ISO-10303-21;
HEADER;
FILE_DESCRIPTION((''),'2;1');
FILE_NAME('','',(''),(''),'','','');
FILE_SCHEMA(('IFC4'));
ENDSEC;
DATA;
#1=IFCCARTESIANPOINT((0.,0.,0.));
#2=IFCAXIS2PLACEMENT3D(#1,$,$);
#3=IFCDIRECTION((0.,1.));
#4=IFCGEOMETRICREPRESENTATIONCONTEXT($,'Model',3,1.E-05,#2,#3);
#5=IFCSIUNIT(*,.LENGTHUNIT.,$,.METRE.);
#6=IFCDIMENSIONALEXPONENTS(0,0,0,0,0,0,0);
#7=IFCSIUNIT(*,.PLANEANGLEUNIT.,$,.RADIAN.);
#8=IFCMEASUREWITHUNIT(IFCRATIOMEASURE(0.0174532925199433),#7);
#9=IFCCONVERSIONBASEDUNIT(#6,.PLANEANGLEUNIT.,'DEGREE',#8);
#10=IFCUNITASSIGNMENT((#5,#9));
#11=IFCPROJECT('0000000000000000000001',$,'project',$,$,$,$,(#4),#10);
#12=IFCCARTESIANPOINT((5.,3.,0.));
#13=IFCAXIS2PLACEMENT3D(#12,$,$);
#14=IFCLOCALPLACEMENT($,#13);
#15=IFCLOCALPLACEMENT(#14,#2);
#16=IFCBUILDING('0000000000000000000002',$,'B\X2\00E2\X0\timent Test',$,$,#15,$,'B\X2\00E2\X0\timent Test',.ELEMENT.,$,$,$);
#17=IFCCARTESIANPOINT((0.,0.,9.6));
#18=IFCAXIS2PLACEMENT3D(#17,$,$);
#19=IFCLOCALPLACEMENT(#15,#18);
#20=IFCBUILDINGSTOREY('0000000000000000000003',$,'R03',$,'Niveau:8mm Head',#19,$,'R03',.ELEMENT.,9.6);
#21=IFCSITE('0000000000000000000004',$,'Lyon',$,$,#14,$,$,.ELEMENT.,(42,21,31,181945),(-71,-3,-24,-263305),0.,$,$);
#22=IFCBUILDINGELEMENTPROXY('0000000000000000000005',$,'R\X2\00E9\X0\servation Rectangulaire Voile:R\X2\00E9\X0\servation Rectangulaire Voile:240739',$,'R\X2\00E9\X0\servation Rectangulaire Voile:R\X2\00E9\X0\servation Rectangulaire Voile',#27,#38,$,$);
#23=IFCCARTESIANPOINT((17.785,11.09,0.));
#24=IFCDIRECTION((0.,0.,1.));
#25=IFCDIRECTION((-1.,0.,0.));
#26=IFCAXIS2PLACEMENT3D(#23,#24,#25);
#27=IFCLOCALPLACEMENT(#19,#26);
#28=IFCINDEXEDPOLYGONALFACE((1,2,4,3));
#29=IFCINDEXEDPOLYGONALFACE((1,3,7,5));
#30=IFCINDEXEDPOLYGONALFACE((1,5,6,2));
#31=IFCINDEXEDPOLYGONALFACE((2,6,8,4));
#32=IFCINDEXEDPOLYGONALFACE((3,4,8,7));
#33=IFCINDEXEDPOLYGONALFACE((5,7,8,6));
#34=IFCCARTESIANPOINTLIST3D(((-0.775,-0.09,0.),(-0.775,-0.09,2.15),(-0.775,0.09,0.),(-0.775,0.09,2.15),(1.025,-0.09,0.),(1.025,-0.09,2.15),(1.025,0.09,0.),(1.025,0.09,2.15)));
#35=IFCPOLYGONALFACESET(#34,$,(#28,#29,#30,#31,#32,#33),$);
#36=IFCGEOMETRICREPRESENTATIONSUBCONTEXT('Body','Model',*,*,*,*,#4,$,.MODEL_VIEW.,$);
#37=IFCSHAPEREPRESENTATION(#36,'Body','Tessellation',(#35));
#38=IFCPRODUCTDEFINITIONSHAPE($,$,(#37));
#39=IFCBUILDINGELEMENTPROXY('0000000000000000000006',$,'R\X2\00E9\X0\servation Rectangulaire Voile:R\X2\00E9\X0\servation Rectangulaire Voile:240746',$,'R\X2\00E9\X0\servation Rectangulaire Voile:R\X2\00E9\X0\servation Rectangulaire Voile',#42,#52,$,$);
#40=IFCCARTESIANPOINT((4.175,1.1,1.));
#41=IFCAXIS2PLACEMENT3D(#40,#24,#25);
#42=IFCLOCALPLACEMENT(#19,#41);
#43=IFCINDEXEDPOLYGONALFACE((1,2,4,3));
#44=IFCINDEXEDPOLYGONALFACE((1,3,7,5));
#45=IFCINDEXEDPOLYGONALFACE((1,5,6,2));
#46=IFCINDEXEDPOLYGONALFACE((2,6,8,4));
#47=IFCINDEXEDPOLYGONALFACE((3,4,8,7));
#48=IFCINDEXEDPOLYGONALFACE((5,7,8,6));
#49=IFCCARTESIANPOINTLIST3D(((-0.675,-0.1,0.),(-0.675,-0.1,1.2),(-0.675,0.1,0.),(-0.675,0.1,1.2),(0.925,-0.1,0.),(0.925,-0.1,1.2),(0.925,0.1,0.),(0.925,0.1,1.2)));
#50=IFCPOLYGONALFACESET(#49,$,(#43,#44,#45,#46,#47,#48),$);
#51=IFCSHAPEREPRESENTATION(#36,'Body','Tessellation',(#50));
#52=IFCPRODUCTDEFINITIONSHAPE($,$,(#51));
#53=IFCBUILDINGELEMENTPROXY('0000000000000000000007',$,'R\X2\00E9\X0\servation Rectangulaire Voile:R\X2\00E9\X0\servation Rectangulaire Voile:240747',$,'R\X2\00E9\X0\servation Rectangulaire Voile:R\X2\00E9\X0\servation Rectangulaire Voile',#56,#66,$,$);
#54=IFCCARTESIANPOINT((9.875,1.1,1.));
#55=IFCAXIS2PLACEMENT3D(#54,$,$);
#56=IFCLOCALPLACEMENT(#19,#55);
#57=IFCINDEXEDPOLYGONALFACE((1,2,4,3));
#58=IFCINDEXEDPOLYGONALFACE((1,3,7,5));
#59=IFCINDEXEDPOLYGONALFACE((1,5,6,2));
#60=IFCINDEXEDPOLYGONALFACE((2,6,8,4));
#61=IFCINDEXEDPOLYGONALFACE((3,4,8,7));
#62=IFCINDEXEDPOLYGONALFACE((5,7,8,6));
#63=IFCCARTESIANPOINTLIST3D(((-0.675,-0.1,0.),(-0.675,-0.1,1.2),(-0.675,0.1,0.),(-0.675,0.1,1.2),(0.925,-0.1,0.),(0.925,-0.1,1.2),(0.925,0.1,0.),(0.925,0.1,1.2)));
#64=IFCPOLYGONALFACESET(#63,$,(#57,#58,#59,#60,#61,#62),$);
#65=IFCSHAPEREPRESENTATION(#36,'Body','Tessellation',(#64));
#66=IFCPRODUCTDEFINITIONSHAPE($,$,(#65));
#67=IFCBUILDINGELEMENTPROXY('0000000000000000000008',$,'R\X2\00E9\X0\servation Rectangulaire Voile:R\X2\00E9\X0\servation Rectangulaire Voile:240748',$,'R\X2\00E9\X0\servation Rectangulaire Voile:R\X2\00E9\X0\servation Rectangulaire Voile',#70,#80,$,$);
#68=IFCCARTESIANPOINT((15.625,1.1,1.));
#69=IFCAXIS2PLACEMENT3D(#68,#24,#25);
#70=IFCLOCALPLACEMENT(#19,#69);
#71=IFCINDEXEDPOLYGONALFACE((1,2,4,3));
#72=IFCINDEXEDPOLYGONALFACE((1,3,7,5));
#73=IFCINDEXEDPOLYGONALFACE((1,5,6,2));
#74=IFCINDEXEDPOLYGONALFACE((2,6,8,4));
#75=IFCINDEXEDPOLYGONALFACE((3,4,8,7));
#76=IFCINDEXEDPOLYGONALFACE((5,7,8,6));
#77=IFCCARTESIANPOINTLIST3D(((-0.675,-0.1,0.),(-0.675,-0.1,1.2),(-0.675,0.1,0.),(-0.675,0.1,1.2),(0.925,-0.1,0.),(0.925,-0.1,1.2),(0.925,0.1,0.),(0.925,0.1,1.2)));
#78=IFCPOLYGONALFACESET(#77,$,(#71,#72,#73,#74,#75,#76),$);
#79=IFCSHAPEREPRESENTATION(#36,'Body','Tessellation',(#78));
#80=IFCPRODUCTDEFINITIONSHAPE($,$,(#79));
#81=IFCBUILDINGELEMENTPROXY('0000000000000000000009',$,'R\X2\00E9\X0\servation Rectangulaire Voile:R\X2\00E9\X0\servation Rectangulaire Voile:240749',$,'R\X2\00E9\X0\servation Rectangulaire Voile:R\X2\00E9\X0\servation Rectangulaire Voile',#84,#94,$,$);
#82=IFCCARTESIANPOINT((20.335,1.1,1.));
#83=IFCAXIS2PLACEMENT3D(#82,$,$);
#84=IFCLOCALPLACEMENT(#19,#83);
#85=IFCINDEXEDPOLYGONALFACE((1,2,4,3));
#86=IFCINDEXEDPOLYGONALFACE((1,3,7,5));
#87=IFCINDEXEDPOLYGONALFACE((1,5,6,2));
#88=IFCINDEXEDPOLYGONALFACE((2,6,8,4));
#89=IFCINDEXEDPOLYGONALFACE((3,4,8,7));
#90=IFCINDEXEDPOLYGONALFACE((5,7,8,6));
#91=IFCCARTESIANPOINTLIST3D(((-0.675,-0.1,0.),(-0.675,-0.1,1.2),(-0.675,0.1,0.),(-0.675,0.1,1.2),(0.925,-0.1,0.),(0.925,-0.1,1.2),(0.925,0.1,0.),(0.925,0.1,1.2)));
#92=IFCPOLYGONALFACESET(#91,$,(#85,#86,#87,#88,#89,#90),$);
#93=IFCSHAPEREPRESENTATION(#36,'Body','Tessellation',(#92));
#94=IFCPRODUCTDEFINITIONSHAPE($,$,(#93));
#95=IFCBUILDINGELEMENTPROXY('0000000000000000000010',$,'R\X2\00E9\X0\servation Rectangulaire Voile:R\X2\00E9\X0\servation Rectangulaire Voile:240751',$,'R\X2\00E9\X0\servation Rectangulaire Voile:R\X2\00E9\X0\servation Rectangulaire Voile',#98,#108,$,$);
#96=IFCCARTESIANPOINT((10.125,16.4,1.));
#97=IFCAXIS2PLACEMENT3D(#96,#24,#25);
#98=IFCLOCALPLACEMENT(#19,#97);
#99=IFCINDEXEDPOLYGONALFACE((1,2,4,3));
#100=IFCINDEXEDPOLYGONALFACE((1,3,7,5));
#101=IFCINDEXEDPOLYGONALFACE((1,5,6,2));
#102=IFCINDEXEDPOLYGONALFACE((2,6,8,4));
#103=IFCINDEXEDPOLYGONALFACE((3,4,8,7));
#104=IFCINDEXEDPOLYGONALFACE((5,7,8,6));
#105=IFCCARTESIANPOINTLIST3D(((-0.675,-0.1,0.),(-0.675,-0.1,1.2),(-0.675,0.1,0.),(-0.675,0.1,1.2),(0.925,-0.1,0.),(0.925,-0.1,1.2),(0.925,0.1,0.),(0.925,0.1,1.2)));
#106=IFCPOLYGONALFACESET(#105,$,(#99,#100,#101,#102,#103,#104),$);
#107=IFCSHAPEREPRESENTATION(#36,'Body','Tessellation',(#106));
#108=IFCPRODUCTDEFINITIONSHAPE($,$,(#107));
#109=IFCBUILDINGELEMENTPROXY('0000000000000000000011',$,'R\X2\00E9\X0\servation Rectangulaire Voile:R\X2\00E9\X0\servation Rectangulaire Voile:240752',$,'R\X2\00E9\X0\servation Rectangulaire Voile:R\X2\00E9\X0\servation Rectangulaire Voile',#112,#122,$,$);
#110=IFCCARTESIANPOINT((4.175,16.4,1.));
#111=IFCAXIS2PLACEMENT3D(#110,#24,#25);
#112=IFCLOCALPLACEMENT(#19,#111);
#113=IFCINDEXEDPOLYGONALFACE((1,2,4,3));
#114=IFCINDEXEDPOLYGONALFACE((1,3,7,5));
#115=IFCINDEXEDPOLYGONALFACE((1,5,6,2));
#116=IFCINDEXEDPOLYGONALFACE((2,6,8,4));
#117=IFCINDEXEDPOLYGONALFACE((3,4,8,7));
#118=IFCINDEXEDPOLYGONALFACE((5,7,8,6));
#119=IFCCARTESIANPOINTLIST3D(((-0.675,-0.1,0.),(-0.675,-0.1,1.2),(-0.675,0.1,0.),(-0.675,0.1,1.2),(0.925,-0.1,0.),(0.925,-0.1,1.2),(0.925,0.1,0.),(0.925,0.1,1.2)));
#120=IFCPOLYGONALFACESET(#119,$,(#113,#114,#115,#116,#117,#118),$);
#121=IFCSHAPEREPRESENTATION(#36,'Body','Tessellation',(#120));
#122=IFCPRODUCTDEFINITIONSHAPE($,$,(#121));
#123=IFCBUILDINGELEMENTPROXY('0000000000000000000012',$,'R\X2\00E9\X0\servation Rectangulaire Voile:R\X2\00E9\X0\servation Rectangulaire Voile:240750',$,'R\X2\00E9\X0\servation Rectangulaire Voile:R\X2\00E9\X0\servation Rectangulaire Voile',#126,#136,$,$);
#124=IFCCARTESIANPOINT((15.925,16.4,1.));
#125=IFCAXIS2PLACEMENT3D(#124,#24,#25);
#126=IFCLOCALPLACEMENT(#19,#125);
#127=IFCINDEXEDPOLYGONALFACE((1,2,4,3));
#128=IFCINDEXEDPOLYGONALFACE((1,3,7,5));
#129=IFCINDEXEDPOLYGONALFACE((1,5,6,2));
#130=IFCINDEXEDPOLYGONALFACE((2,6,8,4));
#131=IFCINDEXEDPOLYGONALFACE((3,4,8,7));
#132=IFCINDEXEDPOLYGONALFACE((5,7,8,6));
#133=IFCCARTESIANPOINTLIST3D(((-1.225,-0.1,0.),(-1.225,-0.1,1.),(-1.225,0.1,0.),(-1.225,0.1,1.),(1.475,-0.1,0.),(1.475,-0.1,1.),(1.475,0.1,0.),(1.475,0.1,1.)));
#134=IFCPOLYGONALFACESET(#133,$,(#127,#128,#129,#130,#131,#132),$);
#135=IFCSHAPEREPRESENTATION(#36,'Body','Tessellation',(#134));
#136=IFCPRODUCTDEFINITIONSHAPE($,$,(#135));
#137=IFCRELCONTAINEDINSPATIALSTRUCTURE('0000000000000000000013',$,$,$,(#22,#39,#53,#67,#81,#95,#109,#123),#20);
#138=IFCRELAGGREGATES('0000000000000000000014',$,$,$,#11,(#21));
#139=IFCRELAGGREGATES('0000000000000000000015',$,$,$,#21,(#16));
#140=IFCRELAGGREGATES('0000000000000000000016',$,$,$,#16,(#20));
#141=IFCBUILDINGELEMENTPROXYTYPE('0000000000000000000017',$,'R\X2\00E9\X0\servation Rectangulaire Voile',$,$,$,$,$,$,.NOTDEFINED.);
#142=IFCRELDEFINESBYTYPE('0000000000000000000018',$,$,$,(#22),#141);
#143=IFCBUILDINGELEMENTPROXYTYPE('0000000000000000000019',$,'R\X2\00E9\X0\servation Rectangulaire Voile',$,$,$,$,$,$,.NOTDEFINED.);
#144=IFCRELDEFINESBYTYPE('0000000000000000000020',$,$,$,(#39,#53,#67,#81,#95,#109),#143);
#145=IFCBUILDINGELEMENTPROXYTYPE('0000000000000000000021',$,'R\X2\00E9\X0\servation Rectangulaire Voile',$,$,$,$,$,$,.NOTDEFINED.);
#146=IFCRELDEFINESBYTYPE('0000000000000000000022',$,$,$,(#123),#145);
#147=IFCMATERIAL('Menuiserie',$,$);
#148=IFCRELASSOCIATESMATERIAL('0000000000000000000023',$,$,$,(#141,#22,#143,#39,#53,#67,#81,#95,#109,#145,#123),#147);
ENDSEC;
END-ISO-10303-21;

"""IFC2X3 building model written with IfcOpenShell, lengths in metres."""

from ifc_helpers import new_model, entity, si_unit, converted_unit, direction, frame, origin, origin_2d_with_axis, place, context, subcontext, project, spatial, rectangle, extrude, source, transform, mapped, material, type_object, type_shapes, element, save


model = new_model("IFC2X3")

# Units and contexts
model_context = context("Model", 3, precision=1e-05, world=origin(), true_north=direction((0.0, 1.0)))
body_context = subcontext(model_context, "Body", "Model", "MODEL_VIEW")
ifc_project = project(units=[si_unit("LENGTHUNIT", "METRE"), converted_unit("PLANEANGLEUNIT", "DEGREE", entity("IfcRatioMeasure", 0.0174532925199433), si_unit("PLANEANGLEUNIT", "RADIAN"), dimensions=[0, 0, 0, 0, 0, 0, 0])], contexts=[model_context])

# Site, building, storey
site_placement = place(None, frame((5.0, 3.0, 0.0)))
site = spatial("IfcSite", under=ifc_project, at=site_placement, Name="Lyon", CompositionType="ELEMENT", RefLatitude=(42, 21, 31, 181945), RefLongitude=(-71, -3, -24, -263305), RefElevation=0.0)
building_placement = place(site_placement, origin())
building = spatial("IfcBuilding", under=site, at=building_placement, Name="Bâtiment Test", LongName="Bâtiment Test", CompositionType="ELEMENT")
storey_placement = place(building_placement, frame((0.0, 0.0, 9.6)))
storey = spatial("IfcBuildingStorey", under=building, at=storey_placement, Name="R03", ObjectType="Niveau:8mm Head", LongName="R03", CompositionType="ELEMENT", Elevation=9.6)

# Building element proxies
ifc_material_1 = material(Name="Menuiserie")
building_element_proxy_type_1 = type_object("IfcBuildingElementProxyType", Name="Réservation Rectangulaire Voile", PredefinedType="NOTDEFINED", material=ifc_material_1)
shared_shape_1 = source(origin(), body_context, "Body", "SweptSolid", [
    extrude(rectangle(XDim=0.18, YDim=1.8, at=origin_2d_with_axis()), frame((0.125, 0.0, 0.0), z_axis=(0.0, 0.0, 1.0), x_axis=(0.0, 1.0, 0.0)), (0.0, 0.0, 1.0), 2.15),
])
type_shapes(building_element_proxy_type_1, [shared_shape_1])
proxy_1_placement = place(storey_placement, frame((17.785, 11.09, 0.0), z_axis=(0.0, 0.0, 1.0), x_axis=(-1.0, 0.0, 0.0)))
element("IfcBuildingElementProxy", 1, at=proxy_1_placement, inside=storey, type_object=building_element_proxy_type_1, material=ifc_material_1, Name="Réservation Rectangulaire Voile:Réservation Rectangulaire Voile:240739", ObjectType="Réservation Rectangulaire Voile:Réservation Rectangulaire Voile", context=body_context, shape_type="MappedRepresentation", body=[
    mapped(shared_shape_1, transform((0.0, 0.0, 0.0), scale=1.0)),
])
building_element_proxy_type_2 = type_object("IfcBuildingElementProxyType", Name="Réservation Rectangulaire Voile", PredefinedType="NOTDEFINED", material=ifc_material_1)
shared_shape_2 = source(origin(), body_context, "Body", "SweptSolid", [
    extrude(rectangle(XDim=0.2, YDim=1.6, at=origin_2d_with_axis()), frame((0.125, 0.0, 0.0), z_axis=(0.0, 0.0, 1.0), x_axis=(0.0, 1.0, 0.0)), (0.0, 0.0, 1.0), 1.2),
])
type_shapes(building_element_proxy_type_2, [shared_shape_2])
proxy_2_placement = place(storey_placement, frame((4.175, 1.1, 1.0), z_axis=(0.0, 0.0, 1.0), x_axis=(-1.0, 0.0, 0.0)))
element("IfcBuildingElementProxy", 2, at=proxy_2_placement, inside=storey, type_object=building_element_proxy_type_2, material=ifc_material_1, Name="Réservation Rectangulaire Voile:Réservation Rectangulaire Voile:240746", ObjectType="Réservation Rectangulaire Voile:Réservation Rectangulaire Voile", context=body_context, shape_type="MappedRepresentation", body=[
    mapped(shared_shape_2, transform((0.0, 0.0, 0.0), scale=1.0)),
])
proxy_3_placement = place(storey_placement, frame((9.875, 1.1, 1.0)))
element("IfcBuildingElementProxy", 3, at=proxy_3_placement, inside=storey, type_object=building_element_proxy_type_2, material=ifc_material_1, Name="Réservation Rectangulaire Voile:Réservation Rectangulaire Voile:240747", ObjectType="Réservation Rectangulaire Voile:Réservation Rectangulaire Voile", context=body_context, shape_type="MappedRepresentation", body=[
    mapped(shared_shape_2, transform((0.0, 0.0, 0.0), scale=1.0)),
])
proxy_4_placement = place(storey_placement, frame((15.625, 1.1, 1.0), z_axis=(0.0, 0.0, 1.0), x_axis=(-1.0, 0.0, 0.0)))
element("IfcBuildingElementProxy", 4, at=proxy_4_placement, inside=storey, type_object=building_element_proxy_type_2, material=ifc_material_1, Name="Réservation Rectangulaire Voile:Réservation Rectangulaire Voile:240748", ObjectType="Réservation Rectangulaire Voile:Réservation Rectangulaire Voile", context=body_context, shape_type="MappedRepresentation", body=[
    mapped(shared_shape_2, transform((0.0, 0.0, 0.0), scale=1.0)),
])
proxy_5_placement = place(storey_placement, frame((20.335, 1.1, 1.0)))
element("IfcBuildingElementProxy", 5, at=proxy_5_placement, inside=storey, type_object=building_element_proxy_type_2, material=ifc_material_1, Name="Réservation Rectangulaire Voile:Réservation Rectangulaire Voile:240749", ObjectType="Réservation Rectangulaire Voile:Réservation Rectangulaire Voile", context=body_context, shape_type="MappedRepresentation", body=[
    mapped(shared_shape_2, transform((0.0, 0.0, 0.0), scale=1.0)),
])
for number, where, z_axis, x_axis, name in (
    (6, (10.125, 16.4, 1.0), (0.0, 0.0, 1.0), (-1.0, 0.0, 0.0), "Réservation Rectangulaire Voile:Réservation Rectangulaire Voile:240751"),
    (7, (4.175, 16.4, 1.0), (0.0, 0.0, 1.0), (-1.0, 0.0, 0.0), "Réservation Rectangulaire Voile:Réservation Rectangulaire Voile:240752"),
):
    element("IfcBuildingElementProxy", number, at=place(storey_placement, frame(where, z_axis=z_axis, x_axis=x_axis)), inside=storey, type_object=building_element_proxy_type_2, material=ifc_material_1, Name=name, ObjectType="Réservation Rectangulaire Voile:Réservation Rectangulaire Voile", context=body_context, shape_type="MappedRepresentation", body=[
        mapped(shared_shape_2, transform((0.0, 0.0, 0.0), scale=1.0)),
    ])
building_element_proxy_type_3 = type_object("IfcBuildingElementProxyType", Name="Réservation Rectangulaire Voile", PredefinedType="NOTDEFINED", material=ifc_material_1)
shared_shape_3 = source(origin(), body_context, "Body", "SweptSolid", [
    extrude(rectangle(XDim=0.2, YDim=2.7, at=origin_2d_with_axis()), frame((0.125, 0.0, 0.0), z_axis=(0.0, 0.0, 1.0), x_axis=(0.0, 1.0, 0.0)), (0.0, 0.0, 1.0), 1.0),
])
type_shapes(building_element_proxy_type_3, [shared_shape_3])
proxy_6_placement = place(storey_placement, frame((15.925, 16.4, 1.0), z_axis=(0.0, 0.0, 1.0), x_axis=(-1.0, 0.0, 0.0)))
element("IfcBuildingElementProxy", 8, at=proxy_6_placement, inside=storey, type_object=building_element_proxy_type_3, material=ifc_material_1, Name="Réservation Rectangulaire Voile:Réservation Rectangulaire Voile:240750", ObjectType="Réservation Rectangulaire Voile:Réservation Rectangulaire Voile", context=body_context, shape_type="MappedRepresentation", body=[
    mapped(shared_shape_3, transform((0.0, 0.0, 0.0), scale=1.0)),
])

save(model, "model.ifc")
